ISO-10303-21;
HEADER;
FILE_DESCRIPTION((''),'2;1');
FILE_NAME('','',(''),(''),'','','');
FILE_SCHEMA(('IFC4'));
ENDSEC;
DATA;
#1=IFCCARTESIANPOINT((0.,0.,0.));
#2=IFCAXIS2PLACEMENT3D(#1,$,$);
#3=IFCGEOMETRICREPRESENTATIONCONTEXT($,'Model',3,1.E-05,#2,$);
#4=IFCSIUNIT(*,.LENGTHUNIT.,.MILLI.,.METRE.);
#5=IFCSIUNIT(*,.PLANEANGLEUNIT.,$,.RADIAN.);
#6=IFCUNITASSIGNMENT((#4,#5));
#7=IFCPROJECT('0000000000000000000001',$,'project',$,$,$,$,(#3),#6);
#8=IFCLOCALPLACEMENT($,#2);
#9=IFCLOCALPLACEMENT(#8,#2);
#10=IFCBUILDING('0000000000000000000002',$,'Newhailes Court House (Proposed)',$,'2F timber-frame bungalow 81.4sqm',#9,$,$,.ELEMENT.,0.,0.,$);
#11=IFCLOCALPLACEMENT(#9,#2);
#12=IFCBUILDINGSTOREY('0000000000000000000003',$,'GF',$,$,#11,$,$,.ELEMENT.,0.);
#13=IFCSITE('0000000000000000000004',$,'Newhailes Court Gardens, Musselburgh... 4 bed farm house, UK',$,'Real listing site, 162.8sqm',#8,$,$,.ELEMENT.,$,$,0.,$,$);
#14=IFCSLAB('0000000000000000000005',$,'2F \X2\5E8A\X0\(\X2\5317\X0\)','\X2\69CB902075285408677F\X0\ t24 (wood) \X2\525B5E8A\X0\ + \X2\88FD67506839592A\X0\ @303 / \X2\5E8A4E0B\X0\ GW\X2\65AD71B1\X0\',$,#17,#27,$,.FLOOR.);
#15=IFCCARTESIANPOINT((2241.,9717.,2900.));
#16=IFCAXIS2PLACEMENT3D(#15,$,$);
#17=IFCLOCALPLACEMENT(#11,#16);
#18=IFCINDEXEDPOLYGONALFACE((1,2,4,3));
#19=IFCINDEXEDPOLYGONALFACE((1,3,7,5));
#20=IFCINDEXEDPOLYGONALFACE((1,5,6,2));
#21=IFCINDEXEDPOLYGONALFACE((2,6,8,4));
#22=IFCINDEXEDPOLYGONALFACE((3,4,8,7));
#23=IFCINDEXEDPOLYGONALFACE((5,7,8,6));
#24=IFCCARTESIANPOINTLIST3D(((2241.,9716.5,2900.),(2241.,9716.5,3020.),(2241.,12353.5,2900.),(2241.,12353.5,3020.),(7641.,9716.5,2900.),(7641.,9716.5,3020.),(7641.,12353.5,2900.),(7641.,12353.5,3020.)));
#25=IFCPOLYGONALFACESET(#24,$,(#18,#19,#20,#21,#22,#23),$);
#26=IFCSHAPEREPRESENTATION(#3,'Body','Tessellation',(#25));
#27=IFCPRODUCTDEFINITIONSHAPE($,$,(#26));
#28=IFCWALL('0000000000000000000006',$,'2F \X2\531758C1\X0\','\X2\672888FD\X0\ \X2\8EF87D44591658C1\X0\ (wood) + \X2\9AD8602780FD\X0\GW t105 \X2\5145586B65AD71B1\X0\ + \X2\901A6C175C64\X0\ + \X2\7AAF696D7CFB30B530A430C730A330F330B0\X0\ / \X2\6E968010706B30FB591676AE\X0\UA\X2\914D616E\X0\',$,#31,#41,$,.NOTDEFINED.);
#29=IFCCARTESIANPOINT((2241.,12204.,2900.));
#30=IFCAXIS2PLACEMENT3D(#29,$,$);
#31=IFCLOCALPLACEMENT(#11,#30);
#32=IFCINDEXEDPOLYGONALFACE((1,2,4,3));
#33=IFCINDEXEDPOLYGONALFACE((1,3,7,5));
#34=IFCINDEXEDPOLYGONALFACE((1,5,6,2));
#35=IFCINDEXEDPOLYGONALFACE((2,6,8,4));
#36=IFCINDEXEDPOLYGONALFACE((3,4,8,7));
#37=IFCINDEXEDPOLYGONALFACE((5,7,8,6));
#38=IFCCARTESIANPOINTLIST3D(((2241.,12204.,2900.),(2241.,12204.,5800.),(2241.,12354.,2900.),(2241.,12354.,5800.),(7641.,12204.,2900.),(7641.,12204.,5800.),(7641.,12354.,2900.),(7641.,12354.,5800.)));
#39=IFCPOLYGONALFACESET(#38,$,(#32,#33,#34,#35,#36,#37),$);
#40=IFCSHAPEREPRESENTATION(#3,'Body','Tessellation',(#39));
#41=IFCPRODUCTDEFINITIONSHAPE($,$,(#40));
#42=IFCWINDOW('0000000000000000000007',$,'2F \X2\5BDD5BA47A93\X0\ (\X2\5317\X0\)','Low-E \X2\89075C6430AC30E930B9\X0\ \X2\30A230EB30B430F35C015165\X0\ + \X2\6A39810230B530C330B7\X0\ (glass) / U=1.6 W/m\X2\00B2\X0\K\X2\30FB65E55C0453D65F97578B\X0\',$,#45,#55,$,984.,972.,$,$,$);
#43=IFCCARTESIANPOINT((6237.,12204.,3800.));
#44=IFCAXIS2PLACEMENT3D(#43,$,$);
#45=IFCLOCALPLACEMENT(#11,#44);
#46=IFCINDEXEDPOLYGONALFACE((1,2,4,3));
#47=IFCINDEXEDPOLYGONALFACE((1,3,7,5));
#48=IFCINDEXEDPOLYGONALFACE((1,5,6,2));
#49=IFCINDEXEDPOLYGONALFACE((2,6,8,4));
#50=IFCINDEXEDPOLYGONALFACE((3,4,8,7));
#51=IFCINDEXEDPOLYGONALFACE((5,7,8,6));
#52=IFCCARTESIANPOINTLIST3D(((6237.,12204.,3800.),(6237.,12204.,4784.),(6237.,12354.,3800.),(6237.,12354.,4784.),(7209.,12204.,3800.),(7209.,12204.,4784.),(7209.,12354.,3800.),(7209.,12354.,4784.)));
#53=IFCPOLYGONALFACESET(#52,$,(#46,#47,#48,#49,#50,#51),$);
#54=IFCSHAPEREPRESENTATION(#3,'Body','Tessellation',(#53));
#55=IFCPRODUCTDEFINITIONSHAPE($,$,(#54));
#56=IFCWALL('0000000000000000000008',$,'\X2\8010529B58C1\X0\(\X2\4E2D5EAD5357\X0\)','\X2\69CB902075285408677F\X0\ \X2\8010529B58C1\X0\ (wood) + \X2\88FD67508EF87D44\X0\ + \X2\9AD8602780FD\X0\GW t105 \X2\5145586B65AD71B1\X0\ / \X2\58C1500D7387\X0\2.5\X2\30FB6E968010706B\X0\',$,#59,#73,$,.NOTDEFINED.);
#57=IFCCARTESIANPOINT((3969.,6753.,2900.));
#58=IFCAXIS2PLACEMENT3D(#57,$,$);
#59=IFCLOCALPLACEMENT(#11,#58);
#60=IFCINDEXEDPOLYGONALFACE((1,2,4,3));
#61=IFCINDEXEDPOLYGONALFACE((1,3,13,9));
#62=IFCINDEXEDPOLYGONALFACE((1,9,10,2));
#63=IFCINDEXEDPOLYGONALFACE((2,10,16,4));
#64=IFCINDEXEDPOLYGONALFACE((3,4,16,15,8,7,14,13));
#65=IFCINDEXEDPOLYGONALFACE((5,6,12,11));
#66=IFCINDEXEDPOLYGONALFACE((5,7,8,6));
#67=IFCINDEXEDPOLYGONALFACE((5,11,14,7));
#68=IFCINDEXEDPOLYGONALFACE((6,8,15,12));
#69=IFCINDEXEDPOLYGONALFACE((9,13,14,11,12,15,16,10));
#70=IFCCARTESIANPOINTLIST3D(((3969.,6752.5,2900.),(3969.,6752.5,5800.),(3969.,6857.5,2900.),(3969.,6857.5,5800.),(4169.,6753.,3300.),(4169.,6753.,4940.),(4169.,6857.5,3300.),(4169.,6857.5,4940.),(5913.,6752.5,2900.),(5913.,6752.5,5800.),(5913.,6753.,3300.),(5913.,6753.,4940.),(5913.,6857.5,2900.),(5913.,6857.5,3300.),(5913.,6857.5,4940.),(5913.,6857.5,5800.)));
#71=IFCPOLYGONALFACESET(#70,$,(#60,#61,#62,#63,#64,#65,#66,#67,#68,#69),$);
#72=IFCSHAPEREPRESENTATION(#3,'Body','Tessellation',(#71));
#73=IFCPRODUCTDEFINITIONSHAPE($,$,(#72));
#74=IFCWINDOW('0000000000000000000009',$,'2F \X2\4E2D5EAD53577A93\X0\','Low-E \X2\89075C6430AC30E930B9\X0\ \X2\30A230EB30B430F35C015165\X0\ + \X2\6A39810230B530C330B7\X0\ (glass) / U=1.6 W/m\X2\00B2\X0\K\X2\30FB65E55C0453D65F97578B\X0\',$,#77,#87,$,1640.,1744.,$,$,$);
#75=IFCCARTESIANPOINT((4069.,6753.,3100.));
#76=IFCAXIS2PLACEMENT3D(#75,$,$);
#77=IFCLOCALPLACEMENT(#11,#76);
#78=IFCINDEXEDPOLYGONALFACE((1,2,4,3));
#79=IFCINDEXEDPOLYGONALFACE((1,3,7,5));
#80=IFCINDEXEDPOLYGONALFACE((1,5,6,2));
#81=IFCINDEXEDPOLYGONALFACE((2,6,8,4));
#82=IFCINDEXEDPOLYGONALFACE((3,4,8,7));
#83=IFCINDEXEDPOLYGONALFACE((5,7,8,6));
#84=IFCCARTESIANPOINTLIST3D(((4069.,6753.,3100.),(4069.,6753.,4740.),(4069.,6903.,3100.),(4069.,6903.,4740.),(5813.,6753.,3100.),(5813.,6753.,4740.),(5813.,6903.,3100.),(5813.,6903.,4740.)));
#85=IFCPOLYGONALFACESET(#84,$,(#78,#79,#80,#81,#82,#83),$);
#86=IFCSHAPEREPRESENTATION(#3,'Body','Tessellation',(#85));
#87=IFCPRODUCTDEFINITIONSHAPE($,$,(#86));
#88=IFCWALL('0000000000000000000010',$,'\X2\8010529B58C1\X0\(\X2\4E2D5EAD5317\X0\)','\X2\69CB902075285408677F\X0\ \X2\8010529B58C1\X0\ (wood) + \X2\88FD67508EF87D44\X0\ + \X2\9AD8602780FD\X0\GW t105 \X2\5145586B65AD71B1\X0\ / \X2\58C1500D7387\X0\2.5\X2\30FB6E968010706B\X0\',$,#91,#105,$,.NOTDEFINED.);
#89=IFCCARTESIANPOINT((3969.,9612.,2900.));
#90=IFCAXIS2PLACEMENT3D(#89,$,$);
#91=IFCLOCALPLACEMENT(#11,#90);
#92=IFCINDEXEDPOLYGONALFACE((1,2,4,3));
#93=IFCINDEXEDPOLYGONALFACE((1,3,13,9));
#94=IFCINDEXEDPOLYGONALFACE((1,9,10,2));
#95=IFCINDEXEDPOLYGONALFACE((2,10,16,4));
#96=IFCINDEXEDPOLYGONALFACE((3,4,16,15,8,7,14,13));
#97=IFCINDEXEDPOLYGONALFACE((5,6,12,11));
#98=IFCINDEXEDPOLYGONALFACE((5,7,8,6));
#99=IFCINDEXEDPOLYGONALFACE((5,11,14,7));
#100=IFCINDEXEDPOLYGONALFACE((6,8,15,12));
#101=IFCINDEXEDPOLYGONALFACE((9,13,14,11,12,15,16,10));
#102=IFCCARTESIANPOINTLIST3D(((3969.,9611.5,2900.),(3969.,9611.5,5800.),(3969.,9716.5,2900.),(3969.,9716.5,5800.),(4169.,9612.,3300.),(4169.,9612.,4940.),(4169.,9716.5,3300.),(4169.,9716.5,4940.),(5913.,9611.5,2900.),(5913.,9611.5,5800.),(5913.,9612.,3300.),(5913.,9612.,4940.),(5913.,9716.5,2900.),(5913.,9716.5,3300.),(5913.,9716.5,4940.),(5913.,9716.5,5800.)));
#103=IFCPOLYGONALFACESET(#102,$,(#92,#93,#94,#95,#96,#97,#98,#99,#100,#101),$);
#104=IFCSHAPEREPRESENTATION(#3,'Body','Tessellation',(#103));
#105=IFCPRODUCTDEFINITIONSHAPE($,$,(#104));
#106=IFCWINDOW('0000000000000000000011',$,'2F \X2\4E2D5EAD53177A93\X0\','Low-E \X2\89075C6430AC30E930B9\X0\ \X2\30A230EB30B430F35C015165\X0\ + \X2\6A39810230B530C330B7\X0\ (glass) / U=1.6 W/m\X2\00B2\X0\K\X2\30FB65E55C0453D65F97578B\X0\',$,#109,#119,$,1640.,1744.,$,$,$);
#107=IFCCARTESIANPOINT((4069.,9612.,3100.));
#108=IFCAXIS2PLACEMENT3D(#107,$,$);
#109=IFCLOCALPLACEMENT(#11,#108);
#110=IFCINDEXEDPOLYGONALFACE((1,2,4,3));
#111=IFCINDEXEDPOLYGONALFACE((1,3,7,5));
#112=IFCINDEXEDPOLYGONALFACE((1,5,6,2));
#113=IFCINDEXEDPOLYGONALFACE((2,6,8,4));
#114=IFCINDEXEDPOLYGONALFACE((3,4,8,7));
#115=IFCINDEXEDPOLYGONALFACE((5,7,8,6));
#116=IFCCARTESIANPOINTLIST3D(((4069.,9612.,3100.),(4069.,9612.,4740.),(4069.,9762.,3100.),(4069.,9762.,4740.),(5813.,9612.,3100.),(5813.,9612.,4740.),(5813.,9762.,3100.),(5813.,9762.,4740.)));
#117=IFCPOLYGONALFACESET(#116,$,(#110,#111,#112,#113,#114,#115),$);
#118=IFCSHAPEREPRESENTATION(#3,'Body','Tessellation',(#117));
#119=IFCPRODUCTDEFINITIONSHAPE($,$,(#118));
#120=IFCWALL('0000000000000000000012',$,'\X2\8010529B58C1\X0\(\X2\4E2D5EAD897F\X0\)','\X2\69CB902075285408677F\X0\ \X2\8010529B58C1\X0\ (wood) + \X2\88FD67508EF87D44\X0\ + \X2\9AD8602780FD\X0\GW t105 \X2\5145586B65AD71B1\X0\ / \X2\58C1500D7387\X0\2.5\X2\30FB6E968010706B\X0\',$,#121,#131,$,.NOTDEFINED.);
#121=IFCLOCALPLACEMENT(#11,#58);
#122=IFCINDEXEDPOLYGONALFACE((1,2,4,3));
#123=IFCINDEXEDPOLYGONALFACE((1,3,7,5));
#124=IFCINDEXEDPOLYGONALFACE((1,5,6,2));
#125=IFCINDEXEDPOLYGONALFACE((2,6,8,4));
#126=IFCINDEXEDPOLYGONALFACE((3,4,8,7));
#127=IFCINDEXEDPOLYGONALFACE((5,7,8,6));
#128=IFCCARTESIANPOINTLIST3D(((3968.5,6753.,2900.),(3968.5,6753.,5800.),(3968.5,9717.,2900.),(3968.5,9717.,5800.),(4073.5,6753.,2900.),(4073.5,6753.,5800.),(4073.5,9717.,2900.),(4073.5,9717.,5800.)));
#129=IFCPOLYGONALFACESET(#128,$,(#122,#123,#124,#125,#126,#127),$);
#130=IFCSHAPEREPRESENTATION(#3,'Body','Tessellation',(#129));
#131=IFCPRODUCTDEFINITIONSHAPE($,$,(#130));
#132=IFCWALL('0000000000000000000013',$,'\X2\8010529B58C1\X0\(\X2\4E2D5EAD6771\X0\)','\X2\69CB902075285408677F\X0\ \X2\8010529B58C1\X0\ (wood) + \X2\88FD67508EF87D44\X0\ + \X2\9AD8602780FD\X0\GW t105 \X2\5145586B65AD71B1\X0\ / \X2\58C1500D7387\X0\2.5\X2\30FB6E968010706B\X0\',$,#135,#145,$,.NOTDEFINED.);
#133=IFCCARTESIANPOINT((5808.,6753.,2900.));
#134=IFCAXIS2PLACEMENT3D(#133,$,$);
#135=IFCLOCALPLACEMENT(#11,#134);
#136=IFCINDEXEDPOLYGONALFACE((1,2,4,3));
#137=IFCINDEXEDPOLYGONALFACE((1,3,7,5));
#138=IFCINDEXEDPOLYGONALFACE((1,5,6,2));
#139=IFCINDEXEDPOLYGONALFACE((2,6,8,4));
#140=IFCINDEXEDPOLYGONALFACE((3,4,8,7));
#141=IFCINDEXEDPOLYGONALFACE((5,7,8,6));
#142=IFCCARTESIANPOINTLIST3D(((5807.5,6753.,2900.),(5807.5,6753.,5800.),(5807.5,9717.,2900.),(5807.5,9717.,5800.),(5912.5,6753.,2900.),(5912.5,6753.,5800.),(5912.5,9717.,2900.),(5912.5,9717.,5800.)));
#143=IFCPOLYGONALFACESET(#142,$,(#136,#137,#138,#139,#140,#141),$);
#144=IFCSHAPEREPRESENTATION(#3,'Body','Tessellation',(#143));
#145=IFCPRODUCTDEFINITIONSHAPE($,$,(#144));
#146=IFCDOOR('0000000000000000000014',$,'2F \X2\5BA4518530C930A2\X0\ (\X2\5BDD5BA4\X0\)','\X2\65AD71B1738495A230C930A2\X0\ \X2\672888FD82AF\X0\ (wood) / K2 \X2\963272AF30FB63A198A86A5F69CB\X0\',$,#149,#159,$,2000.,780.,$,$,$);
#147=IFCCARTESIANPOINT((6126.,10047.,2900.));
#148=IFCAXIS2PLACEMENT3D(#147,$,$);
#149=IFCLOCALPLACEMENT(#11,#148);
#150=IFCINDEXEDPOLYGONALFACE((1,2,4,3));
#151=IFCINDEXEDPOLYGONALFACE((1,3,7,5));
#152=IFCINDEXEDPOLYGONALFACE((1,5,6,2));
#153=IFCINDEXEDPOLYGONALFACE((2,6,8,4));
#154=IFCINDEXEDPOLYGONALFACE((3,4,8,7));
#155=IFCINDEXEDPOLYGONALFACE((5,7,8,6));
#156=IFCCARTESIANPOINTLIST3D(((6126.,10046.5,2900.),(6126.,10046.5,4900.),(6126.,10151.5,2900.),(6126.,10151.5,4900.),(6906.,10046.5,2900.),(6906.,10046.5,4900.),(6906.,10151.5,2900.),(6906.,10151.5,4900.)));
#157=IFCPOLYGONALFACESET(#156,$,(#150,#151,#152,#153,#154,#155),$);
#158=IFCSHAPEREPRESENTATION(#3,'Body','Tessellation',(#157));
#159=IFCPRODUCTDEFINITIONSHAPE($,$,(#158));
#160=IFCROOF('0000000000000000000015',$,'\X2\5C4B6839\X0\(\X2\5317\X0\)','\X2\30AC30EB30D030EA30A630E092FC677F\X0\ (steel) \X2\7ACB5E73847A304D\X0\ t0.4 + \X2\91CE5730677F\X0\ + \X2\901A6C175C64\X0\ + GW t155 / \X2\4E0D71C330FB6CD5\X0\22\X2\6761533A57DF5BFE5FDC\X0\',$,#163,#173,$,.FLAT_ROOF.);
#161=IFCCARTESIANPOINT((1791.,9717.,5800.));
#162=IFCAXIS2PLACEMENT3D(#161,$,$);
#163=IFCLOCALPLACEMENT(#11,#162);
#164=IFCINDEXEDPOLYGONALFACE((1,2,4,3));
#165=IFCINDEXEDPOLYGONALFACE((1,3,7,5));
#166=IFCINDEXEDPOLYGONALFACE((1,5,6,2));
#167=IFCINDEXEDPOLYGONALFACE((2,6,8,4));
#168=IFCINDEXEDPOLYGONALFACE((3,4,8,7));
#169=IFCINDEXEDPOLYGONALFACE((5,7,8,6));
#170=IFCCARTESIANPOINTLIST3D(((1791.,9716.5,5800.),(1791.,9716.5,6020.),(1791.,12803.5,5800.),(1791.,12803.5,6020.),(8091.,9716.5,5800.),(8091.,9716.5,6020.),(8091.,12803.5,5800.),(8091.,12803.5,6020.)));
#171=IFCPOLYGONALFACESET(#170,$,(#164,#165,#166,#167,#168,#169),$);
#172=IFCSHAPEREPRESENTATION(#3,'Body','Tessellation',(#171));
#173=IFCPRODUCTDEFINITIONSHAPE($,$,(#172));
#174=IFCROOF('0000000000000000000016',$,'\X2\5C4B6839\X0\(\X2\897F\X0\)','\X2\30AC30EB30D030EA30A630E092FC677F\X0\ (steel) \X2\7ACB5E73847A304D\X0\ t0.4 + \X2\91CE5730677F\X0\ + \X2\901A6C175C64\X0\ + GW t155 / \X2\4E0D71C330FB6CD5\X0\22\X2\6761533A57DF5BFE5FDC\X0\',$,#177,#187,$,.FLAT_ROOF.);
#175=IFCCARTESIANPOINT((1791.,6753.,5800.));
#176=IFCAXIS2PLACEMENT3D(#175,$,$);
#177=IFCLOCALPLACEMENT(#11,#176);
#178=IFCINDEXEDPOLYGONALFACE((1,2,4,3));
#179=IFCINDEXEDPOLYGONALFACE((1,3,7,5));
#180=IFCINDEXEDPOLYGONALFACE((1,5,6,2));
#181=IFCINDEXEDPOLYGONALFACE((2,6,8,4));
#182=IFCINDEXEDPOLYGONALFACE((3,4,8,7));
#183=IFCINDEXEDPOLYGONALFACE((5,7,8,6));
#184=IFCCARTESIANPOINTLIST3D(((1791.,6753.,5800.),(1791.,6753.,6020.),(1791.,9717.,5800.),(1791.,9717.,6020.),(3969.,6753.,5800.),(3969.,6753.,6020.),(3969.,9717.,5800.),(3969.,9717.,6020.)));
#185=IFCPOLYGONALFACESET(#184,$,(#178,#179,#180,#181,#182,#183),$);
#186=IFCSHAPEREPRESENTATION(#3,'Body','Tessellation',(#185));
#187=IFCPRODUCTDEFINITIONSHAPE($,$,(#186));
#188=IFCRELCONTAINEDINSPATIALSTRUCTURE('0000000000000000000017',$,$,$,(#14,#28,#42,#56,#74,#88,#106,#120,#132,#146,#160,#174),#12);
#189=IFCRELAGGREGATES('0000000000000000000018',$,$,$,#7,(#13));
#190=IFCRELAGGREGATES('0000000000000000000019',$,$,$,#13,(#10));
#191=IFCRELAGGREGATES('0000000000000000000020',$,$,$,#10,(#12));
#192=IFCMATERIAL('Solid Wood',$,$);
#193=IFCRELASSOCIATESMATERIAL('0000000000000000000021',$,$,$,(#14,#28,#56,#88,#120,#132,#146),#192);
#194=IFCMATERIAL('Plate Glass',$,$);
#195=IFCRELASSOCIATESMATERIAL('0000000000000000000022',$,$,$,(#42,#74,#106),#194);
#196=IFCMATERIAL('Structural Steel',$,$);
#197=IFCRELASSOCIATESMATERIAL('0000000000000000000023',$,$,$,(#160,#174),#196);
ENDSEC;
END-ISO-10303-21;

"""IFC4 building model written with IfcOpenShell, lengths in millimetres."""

from ifc_helpers import new_model, si_unit, frame, frame_2d, origin, place, context, project, spatial, rectangle, extrude, material, element, fill, save


model = new_model("IFC4")

# Units and contexts
model_context = context("Model", 3, precision=1e-05, world=origin())
ifc_project = project(units=[si_unit("LENGTHUNIT", "METRE", prefix="MILLI"), si_unit("PLANEANGLEUNIT", "RADIAN")], contexts=[model_context])

# Site, building, storey
site_placement = place(None, origin())
site = spatial("IfcSite", under=ifc_project, at=site_placement, Name="Newhailes Court Gardens, Musselburgh... 4 bed farm house, UK", ObjectType="Real listing site, 162.8sqm", CompositionType="ELEMENT", RefElevation=0.0)
building_placement = place(site_placement, origin())
building = spatial("IfcBuilding", under=site, at=building_placement, Name="Newhailes Court House (Proposed)", ObjectType="2F timber-frame bungalow 81.4sqm", CompositionType="ELEMENT", ElevationOfRefHeight=0.0, ElevationOfTerrain=0.0)
storey_placement = place(building_placement, origin())
storey = spatial("IfcBuildingStorey", under=building, at=storey_placement, Name="GF", CompositionType="ELEMENT", Elevation=0.0)

# Slab
ifc_material_1 = material(Name="Solid Wood")
slab_placement = place(storey_placement, frame((2241.0, 9717.0, 2900.0)))
element("IfcSlab", 1, at=slab_placement, inside=storey, material=ifc_material_1, Name="2F 床(北)", Description="構造用合板 t24 (wood) 剛床 + 製材根太 @303 / 床下 GW断熱", PredefinedType="FLOOR", context=model_context, shape_type="SweptSolid", body=[
    extrude(rectangle(XDim=5400.0, YDim=2637.0, at=frame_2d((2700.0, 1318.0))), frame((2241.0, 9717.0, 2900.0)), (0.0, 0.0, 1.0), 120.0),
])

# Walls, openings, windows
wall_1_placement = place(storey_placement, frame((2241.0, 12204.0, 2900.0)))
wall_1 = element("IfcWall", 2, at=wall_1_placement, inside=storey, material=ifc_material_1, Name="2F 北壁", Description="木製 軸組外壁 (wood) + 高性能GW t105 充填断熱 + 通気層 + 窯業系サイディング / 準耐火・外皮UA配慮", PredefinedType="NOTDEFINED", context=model_context, shape_type="SweptSolid", body=[
    extrude(rectangle(XDim=5400.0, YDim=150.0, at=frame_2d((2700.0, 75.0))), frame((2241.0, 12204.0, 2900.0)), (0.0, 0.0, 1.0), 2900.0),
])
opening_1_placement = place(storey_placement, frame((6237.0, 12204.0, 3800.0)))
opening_1 = element("IfcOpeningElement", 3, at=opening_1_placement, cuts=wall_1, PredefinedType="NOTDEFINED", context=model_context, shape_type="SweptSolid", body=[
    extrude(rectangle(XDim=972.0, YDim=150.0, at=frame_2d((486.0, 75.0))), frame((6237.0, 12204.0, 3800.0)), (0.0, 0.0, 1.0), 984.0),
])
ifc_material_2 = material(Name="Plate Glass")
window_1_placement = place(storey_placement, frame((6237.0, 12204.0, 3800.0)))
window_1 = element("IfcWindow", 4, at=window_1_placement, inside=storey, material=ifc_material_2, Name="2F 寝室窓 (北)", Description="Low-E 複層ガラス アルゴン封入 + 樹脂サッシ (glass) / U=1.6 W/m²K・日射取得型", OverallHeight=984.0, OverallWidth=972.0, context=model_context, shape_type="SweptSolid", body=[
    extrude(rectangle(XDim=972.0, YDim=150.0, at=frame_2d((486.0, 75.0))), frame((6237.0, 12204.0, 3800.0)), (0.0, 0.0, 1.0), 984.0),
])
fill(opening_1, window_1)
wall_2_placement = place(storey_placement, frame((3969.0, 6753.0, 2900.0)))
wall_2 = element("IfcWall", 5, at=wall_2_placement, inside=storey, material=ifc_material_1, Name="耐力壁(中庭南)", Description="構造用合板 耐力壁 (wood) + 製材軸組 + 高性能GW t105 充填断熱 / 壁倍率2.5・準耐火", PredefinedType="NOTDEFINED", context=model_context, shape_type="SweptSolid", body=[
    extrude(rectangle(XDim=1944.0, YDim=105.0, at=frame_2d((972.0, 52.0))), frame((3969.0, 6753.0, 2900.0)), (0.0, 0.0, 1.0), 2900.0),
])
opening_2_placement = place(storey_placement, frame((4069.0, 6753.0, 3100.0)))
opening_2 = element("IfcOpeningElement", 6, at=opening_2_placement, cuts=wall_2, PredefinedType="NOTDEFINED", context=model_context, shape_type="SweptSolid", body=[
    extrude(rectangle(XDim=1744.0, YDim=150.0, at=frame_2d((872.0, 75.0))), frame((4069.0, 6753.0, 3100.0)), (0.0, 0.0, 1.0), 1640.0),
])
window_2_placement = place(storey_placement, frame((4069.0, 6753.0, 3100.0)))
window_2 = element("IfcWindow", 7, at=window_2_placement, inside=storey, material=ifc_material_2, Name="2F 中庭南窓", Description="Low-E 複層ガラス アルゴン封入 + 樹脂サッシ (glass) / U=1.6 W/m²K・日射取得型", OverallHeight=1640.0, OverallWidth=1744.0, context=model_context, shape_type="SweptSolid", body=[
    extrude(rectangle(XDim=1744.0, YDim=150.0, at=frame_2d((872.0, 75.0))), frame((4069.0, 6753.0, 3100.0)), (0.0, 0.0, 1.0), 1640.0),
])
fill(opening_2, window_2)
wall_3_placement = place(storey_placement, frame((3969.0, 9612.0, 2900.0)))
wall_3 = element("IfcWall", 8, at=wall_3_placement, inside=storey, material=ifc_material_1, Name="耐力壁(中庭北)", Description="構造用合板 耐力壁 (wood) + 製材軸組 + 高性能GW t105 充填断熱 / 壁倍率2.5・準耐火", PredefinedType="NOTDEFINED", context=model_context, shape_type="SweptSolid", body=[
    extrude(rectangle(XDim=1944.0, YDim=105.0, at=frame_2d((972.0, 52.0))), frame((3969.0, 9612.0, 2900.0)), (0.0, 0.0, 1.0), 2900.0),
])
opening_3_placement = place(storey_placement, frame((4069.0, 9612.0, 3100.0)))
opening_3 = element("IfcOpeningElement", 9, at=opening_3_placement, cuts=wall_3, PredefinedType="NOTDEFINED", context=model_context, shape_type="SweptSolid", body=[
    extrude(rectangle(XDim=1744.0, YDim=150.0, at=frame_2d((872.0, 75.0))), frame((4069.0, 9612.0, 3100.0)), (0.0, 0.0, 1.0), 1640.0),
])
window_3_placement = place(storey_placement, frame((4069.0, 9612.0, 3100.0)))
window_3 = element("IfcWindow", 10, at=window_3_placement, inside=storey, material=ifc_material_2, Name="2F 中庭北窓", Description="Low-E 複層ガラス アルゴン封入 + 樹脂サッシ (glass) / U=1.6 W/m²K・日射取得型", OverallHeight=1640.0, OverallWidth=1744.0, context=model_context, shape_type="SweptSolid", body=[
    extrude(rectangle(XDim=1744.0, YDim=150.0, at=frame_2d((872.0, 75.0))), frame((4069.0, 9612.0, 3100.0)), (0.0, 0.0, 1.0), 1640.0),
])
fill(opening_3, window_3)

# Walls
wall_4_placement = place(storey_placement, frame((3969.0, 6753.0, 2900.0)))
element("IfcWall", 11, at=wall_4_placement, inside=storey, material=ifc_material_1, Name="耐力壁(中庭西)", Description="構造用合板 耐力壁 (wood) + 製材軸組 + 高性能GW t105 充填断熱 / 壁倍率2.5・準耐火", PredefinedType="NOTDEFINED", context=model_context, shape_type="SweptSolid", body=[
    extrude(rectangle(XDim=105.0, YDim=2964.0, at=frame_2d((52.0, 1482.0))), frame((3969.0, 6753.0, 2900.0)), (0.0, 0.0, 1.0), 2900.0),
])
wall_5_placement = place(storey_placement, frame((5808.0, 6753.0, 2900.0)))
element("IfcWall", 12, at=wall_5_placement, inside=storey, material=ifc_material_1, Name="耐力壁(中庭東)", Description="構造用合板 耐力壁 (wood) + 製材軸組 + 高性能GW t105 充填断熱 / 壁倍率2.5・準耐火", PredefinedType="NOTDEFINED", context=model_context, shape_type="SweptSolid", body=[
    extrude(rectangle(XDim=105.0, YDim=2964.0, at=frame_2d((52.0, 1482.0))), frame((5808.0, 6753.0, 2900.0)), (0.0, 0.0, 1.0), 2900.0),
])

# Door
door_placement = place(storey_placement, frame((6126.0, 10047.0, 2900.0)))
element("IfcDoor", 13, at=door_placement, inside=storey, material=ifc_material_1, Name="2F 室内ドア (寝室)", Description="断熱玄関ドア 木製芯 (wood) / K2 防犯・採風機構", OverallHeight=2000.0, OverallWidth=780.0, context=model_context, shape_type="SweptSolid", body=[
    extrude(rectangle(XDim=780.0, YDim=105.0, at=frame_2d((390.0, 52.0))), frame((6126.0, 10047.0, 2900.0)), (0.0, 0.0, 1.0), 2000.0),
])

# Roofs
ifc_material_3 = material(Name="Structural Steel")
for number, where, name in (
    (14, (1791.0, 9717.0, 5800.0), "屋根(北)"),
):
    element("IfcRoof", number, at=place(storey_placement, frame(where)), inside=storey, material=ifc_material_3, Name=name, Description="ガルバリウム鋼板 (steel) 立平葺き t0.4 + 野地板 + 通気層 + GW t155 / 不燃・法22条区域対応", PredefinedType="FLAT_ROOF", context=model_context, shape_type="SweptSolid", body=[
        extrude(rectangle(XDim=6300.0, YDim=3087.0, at=frame_2d((3150.0, 1543.0))), frame((1791.0, 9717.0, 5800.0)), (0.0, 0.0, 1.0), 220.0),
    ])
roof_1_placement = place(storey_placement, frame((1791.0, 6753.0, 5800.0)))
element("IfcRoof", 15, at=roof_1_placement, inside=storey, material=ifc_material_3, Name="屋根(西)", Description="ガルバリウム鋼板 (steel) 立平葺き t0.4 + 野地板 + 通気層 + GW t155 / 不燃・法22条区域対応", PredefinedType="FLAT_ROOF", context=model_context, shape_type="SweptSolid", body=[
    extrude(rectangle(XDim=2178.0, YDim=2964.0, at=frame_2d((1089.0, 1482.0))), frame((1791.0, 6753.0, 5800.0)), (0.0, 0.0, 1.0), 220.0),
])

save(model, "model.ifc")
